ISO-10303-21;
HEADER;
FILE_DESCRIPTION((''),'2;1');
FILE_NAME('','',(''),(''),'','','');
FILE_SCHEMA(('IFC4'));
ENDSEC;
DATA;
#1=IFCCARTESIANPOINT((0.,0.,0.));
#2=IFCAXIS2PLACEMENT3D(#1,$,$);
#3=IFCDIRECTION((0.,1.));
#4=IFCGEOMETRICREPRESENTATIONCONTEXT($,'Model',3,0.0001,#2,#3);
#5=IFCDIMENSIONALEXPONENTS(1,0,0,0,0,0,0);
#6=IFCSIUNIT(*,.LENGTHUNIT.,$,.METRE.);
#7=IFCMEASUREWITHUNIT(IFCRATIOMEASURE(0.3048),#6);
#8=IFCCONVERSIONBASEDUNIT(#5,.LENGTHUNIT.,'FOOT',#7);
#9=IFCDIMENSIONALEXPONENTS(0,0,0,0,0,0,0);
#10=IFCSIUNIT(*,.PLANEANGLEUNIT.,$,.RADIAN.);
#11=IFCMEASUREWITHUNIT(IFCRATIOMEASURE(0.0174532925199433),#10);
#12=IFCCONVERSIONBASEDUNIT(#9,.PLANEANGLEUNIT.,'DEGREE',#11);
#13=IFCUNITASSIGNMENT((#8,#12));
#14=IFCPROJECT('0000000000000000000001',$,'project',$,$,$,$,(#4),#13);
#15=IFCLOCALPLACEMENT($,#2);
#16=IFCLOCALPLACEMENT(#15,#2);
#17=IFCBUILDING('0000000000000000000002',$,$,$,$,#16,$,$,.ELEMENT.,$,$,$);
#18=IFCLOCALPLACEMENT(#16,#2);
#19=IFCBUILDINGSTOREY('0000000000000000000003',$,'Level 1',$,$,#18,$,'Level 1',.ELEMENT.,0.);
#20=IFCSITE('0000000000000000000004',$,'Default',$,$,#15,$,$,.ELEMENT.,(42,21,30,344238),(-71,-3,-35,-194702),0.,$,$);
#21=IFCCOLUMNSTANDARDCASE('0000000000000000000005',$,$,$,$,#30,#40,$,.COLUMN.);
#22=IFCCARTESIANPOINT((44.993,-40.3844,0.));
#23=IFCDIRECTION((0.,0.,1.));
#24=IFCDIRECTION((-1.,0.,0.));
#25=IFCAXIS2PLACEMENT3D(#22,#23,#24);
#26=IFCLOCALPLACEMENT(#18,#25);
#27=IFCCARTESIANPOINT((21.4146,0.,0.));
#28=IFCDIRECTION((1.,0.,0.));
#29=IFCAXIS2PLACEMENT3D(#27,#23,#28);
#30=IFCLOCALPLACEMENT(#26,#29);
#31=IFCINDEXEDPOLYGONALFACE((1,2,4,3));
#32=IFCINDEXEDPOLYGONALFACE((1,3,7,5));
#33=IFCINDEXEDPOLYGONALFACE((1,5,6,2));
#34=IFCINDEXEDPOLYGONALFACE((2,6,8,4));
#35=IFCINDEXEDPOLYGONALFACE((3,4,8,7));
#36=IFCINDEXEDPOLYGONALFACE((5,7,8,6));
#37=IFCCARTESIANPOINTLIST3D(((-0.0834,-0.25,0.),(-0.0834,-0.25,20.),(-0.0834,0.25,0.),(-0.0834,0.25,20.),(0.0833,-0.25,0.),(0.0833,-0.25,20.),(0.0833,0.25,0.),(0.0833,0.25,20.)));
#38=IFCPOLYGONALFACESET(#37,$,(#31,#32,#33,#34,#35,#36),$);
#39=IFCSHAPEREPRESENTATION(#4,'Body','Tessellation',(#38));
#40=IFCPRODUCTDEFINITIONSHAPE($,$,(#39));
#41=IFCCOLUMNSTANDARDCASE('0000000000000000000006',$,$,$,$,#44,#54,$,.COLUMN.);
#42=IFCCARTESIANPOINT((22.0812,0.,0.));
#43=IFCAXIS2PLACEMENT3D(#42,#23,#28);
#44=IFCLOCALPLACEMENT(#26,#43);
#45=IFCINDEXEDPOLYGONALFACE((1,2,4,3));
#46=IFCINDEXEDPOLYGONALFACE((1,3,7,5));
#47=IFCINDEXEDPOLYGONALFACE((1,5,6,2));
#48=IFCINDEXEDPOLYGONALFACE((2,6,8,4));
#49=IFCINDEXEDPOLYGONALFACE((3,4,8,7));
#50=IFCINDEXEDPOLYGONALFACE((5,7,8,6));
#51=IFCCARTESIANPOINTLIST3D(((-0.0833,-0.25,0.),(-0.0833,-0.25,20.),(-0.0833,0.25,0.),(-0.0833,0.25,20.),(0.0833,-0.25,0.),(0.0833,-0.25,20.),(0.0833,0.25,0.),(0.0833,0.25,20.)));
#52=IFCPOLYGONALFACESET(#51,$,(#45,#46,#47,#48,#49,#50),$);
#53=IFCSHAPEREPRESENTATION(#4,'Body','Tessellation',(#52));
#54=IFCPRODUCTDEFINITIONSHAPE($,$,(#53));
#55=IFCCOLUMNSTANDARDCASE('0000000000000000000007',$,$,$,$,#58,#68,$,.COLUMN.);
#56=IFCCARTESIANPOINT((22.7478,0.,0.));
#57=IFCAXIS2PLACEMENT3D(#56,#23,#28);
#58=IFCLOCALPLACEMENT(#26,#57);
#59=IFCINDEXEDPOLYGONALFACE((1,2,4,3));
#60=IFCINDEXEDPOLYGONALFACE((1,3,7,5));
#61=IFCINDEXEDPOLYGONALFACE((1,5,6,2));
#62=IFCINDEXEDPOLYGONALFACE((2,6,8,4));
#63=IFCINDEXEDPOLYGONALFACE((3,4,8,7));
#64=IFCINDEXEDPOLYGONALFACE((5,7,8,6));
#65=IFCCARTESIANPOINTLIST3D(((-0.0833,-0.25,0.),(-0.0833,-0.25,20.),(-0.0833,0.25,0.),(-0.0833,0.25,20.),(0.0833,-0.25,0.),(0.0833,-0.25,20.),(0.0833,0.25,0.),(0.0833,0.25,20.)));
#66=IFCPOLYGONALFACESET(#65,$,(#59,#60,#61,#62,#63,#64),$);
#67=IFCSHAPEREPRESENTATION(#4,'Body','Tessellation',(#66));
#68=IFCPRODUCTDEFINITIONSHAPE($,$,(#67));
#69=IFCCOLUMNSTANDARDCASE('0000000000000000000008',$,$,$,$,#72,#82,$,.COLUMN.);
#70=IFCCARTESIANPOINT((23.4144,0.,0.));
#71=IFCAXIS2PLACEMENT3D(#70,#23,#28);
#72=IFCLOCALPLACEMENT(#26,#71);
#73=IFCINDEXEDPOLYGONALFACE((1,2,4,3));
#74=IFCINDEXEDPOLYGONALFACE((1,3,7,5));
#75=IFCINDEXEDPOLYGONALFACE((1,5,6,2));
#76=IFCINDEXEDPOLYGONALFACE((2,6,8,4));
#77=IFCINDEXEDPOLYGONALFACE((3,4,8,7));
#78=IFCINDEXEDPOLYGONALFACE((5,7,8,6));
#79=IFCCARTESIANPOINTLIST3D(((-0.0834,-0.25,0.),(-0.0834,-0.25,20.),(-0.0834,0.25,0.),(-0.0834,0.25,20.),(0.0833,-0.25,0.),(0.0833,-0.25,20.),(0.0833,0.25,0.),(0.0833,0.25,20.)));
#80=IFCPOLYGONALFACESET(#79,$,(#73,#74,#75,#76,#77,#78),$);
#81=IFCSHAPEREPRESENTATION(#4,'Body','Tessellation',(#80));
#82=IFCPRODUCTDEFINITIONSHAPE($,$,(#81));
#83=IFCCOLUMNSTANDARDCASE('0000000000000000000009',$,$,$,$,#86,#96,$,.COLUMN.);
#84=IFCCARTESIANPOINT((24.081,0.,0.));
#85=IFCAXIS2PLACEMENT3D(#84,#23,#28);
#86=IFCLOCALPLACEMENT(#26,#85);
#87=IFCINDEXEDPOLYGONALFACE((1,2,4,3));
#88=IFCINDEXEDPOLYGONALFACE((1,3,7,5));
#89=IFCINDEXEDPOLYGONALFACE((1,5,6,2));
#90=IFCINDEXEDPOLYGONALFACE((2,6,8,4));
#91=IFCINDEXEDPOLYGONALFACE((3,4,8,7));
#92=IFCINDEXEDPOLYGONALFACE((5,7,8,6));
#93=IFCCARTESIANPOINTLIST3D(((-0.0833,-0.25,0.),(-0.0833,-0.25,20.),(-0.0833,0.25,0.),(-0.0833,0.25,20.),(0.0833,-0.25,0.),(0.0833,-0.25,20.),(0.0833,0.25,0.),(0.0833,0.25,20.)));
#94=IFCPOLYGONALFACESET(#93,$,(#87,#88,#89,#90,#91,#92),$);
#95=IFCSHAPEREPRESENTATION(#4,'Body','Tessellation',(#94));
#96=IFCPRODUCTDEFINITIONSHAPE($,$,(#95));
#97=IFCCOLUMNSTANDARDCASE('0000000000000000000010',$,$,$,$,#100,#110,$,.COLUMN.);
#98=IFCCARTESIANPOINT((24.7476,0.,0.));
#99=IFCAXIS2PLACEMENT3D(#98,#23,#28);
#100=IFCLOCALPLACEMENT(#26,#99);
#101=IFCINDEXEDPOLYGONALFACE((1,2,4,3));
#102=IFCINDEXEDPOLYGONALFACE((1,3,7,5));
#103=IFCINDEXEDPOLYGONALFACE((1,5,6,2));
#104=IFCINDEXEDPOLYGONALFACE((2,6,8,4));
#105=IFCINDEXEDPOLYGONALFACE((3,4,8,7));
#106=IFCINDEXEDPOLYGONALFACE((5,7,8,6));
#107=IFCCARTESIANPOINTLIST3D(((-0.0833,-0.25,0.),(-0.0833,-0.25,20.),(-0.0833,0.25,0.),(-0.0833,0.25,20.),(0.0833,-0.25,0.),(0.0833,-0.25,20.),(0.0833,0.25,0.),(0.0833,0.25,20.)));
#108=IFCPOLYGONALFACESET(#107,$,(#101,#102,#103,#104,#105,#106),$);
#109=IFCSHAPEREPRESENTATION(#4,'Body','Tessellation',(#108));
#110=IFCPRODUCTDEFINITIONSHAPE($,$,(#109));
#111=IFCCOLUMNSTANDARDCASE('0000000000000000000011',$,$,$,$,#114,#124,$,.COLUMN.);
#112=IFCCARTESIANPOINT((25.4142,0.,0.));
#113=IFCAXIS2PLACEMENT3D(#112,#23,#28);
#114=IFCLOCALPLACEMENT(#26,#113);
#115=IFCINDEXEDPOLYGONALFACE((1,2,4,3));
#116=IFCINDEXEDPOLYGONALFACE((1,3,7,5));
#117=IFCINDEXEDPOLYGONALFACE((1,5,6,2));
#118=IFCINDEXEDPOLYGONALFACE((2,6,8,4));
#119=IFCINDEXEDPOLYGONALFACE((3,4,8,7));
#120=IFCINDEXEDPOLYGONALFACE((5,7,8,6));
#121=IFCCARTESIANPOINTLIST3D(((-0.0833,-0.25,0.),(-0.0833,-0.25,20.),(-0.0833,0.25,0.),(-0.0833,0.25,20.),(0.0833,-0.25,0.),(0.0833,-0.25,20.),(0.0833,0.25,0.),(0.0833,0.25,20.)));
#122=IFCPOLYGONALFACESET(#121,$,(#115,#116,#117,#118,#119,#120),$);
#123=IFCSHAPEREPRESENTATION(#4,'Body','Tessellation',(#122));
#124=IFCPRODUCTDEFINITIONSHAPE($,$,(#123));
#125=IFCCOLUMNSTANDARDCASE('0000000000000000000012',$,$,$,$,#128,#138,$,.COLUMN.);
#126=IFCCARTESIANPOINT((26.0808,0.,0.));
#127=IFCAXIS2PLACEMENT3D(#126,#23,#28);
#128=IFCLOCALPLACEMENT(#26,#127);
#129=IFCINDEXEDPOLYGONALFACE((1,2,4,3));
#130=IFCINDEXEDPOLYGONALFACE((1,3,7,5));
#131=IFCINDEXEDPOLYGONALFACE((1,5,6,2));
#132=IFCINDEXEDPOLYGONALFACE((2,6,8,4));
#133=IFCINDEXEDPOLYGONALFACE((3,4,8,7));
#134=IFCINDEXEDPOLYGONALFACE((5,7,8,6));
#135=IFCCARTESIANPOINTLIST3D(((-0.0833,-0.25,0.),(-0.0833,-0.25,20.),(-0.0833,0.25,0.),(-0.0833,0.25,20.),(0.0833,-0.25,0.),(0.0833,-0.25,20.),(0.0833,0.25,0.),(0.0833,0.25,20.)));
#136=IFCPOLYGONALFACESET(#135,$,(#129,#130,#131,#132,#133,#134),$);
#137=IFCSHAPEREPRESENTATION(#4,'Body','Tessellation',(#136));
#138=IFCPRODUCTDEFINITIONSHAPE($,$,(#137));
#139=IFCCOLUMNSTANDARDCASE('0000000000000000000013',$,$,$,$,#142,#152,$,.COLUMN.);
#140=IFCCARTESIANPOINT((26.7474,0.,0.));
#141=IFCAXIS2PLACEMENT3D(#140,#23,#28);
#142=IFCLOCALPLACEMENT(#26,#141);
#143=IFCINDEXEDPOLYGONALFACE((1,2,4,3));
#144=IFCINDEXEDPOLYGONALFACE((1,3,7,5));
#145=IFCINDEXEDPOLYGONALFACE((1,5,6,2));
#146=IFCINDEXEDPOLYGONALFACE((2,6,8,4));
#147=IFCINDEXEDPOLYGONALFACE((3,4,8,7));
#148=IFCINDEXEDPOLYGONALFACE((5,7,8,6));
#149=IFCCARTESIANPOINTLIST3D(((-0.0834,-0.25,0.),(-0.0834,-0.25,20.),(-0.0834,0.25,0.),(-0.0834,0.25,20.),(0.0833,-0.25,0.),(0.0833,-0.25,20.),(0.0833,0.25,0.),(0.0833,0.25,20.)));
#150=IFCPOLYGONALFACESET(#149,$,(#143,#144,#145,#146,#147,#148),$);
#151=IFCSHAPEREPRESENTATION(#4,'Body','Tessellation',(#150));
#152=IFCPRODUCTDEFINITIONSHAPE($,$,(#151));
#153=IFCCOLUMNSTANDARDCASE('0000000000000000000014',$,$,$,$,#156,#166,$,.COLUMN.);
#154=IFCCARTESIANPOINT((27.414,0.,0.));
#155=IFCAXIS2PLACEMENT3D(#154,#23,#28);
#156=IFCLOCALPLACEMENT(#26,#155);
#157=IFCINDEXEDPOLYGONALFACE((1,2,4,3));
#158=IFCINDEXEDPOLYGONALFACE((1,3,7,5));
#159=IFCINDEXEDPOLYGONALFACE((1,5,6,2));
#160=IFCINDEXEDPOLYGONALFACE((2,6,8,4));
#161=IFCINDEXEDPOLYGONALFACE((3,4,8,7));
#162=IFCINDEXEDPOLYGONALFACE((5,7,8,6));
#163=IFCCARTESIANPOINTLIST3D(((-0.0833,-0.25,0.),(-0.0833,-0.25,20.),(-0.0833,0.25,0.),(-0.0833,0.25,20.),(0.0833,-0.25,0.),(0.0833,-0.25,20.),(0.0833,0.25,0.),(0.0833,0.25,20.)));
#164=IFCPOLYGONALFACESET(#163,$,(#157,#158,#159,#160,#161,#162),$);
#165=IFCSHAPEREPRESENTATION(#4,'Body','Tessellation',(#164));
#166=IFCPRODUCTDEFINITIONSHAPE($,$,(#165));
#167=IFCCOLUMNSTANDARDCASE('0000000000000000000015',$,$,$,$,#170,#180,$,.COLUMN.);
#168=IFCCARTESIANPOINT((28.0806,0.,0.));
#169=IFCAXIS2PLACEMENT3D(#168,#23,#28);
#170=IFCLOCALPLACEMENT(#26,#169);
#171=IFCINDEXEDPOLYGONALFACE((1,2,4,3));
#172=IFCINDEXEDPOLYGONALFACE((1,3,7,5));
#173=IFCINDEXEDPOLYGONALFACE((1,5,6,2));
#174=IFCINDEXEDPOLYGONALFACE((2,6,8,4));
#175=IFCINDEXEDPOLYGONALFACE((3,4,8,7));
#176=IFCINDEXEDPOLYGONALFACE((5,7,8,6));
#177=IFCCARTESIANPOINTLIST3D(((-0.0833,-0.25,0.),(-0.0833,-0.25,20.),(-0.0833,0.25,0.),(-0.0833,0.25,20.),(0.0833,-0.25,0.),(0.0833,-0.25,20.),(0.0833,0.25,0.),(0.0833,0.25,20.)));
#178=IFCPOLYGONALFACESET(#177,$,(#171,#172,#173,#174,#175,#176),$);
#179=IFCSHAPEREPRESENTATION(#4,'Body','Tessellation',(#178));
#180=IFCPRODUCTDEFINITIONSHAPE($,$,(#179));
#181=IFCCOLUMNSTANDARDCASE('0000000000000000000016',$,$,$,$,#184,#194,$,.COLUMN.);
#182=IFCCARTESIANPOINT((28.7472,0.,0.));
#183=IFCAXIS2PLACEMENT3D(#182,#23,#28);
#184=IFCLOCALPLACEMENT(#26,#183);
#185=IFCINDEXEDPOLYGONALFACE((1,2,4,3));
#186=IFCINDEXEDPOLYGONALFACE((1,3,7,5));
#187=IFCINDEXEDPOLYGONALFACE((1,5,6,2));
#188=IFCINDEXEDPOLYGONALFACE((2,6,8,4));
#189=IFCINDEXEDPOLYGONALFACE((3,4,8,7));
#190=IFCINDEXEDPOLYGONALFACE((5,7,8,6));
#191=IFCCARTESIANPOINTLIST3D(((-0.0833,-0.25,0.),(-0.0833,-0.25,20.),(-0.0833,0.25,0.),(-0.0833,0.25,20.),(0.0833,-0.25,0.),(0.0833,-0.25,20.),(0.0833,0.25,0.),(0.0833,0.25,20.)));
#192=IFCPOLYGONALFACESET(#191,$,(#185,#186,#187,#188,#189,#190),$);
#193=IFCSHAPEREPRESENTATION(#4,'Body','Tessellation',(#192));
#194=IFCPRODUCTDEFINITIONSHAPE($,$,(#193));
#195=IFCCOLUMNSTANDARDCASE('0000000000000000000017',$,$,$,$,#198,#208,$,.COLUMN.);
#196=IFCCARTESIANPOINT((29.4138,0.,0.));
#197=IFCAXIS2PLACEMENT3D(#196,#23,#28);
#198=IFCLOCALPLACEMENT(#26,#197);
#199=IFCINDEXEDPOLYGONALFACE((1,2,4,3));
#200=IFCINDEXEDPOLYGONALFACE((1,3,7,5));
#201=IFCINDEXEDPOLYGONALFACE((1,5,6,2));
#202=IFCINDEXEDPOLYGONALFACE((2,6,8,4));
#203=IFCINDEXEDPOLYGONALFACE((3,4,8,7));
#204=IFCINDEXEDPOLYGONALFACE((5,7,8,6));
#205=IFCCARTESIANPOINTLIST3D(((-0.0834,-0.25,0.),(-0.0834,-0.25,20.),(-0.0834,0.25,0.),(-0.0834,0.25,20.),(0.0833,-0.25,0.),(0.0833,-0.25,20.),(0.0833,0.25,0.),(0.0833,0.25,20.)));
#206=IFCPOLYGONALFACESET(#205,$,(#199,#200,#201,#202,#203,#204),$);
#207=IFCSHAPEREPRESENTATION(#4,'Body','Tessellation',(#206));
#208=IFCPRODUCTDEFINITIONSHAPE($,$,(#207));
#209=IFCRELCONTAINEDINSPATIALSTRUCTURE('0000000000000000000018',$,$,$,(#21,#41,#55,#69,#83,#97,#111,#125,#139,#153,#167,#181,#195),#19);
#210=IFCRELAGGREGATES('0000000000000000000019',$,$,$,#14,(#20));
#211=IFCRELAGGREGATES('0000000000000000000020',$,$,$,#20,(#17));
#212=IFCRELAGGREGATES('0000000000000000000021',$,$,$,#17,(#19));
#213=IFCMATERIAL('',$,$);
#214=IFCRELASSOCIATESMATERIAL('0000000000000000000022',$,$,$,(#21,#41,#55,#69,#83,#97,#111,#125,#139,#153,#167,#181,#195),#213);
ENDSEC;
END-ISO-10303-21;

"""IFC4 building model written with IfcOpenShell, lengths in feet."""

from ifc_helpers import new_model, entity, si_unit, converted_unit, direction, frame, origin, place, context, project, spatial, rectangle, extrude, material, element, save


model = new_model("IFC4")

# Units and contexts
model_context = context("Model", 3, precision=0.0001, world=origin(), true_north=direction((0.0, 1.0)))
ifc_project = project(units=[converted_unit("LENGTHUNIT", "FOOT", entity("IfcRatioMeasure", 0.3048), si_unit("LENGTHUNIT", "METRE"), dimensions=[1, 0, 0, 0, 0, 0, 0]), converted_unit("PLANEANGLEUNIT", "DEGREE", entity("IfcRatioMeasure", 0.0174532925199433), si_unit("PLANEANGLEUNIT", "RADIAN"), dimensions=[0, 0, 0, 0, 0, 0, 0])], contexts=[model_context])

# Site, building, storey
site_placement = place(None, origin())
site = spatial("IfcSite", under=ifc_project, at=site_placement, Name="Default", CompositionType="ELEMENT", RefLatitude=(42, 21, 30, 344238), RefLongitude=(-71, -3, -35, -194702), RefElevation=0.0)
building_placement = place(site_placement, origin())
building = spatial("IfcBuilding", under=site, at=building_placement, CompositionType="ELEMENT")
storey_placement = place(building_placement, origin())
storey = spatial("IfcBuildingStorey", under=building, at=storey_placement, Name="Level 1", LongName="Level 1", CompositionType="ELEMENT", Elevation=0.0)

# Columns
ifc_material = material(Name="")
placement = place(storey_placement, frame((44.993, -40.3844, 0.0), z_axis=(0.0, 0.0, 1.0), x_axis=(-1.0, 0.0, 0.0)))
for number, where, z_axis, x_axis in (
    (1, (21.4146, 0.0, 0.0), (0.0, 0.0, 1.0), (1.0, 0.0, 0.0)),
    (2, (22.0812, 0.0, 0.0), (0.0, 0.0, 1.0), (1.0, 0.0, 0.0)),
    (3, (22.7478, 0.0, 0.0), (0.0, 0.0, 1.0), (1.0, 0.0, 0.0)),
    (4, (23.4144, 0.0, 0.0), (0.0, 0.0, 1.0), (1.0, 0.0, 0.0)),
    (5, (24.081, 0.0, 0.0), (0.0, 0.0, 1.0), (1.0, 0.0, 0.0)),
    (6, (24.7476, 0.0, 0.0), (0.0, 0.0, 1.0), (1.0, 0.0, 0.0)),
    (7, (25.4142, 0.0, 0.0), (0.0, 0.0, 1.0), (1.0, 0.0, 0.0)),
    (8, (26.0808, 0.0, 0.0), (0.0, 0.0, 1.0), (1.0, 0.0, 0.0)),
    (9, (26.7474, 0.0, 0.0), (0.0, 0.0, 1.0), (1.0, 0.0, 0.0)),
    (10, (27.414, 0.0, 0.0), (0.0, 0.0, 1.0), (1.0, 0.0, 0.0)),
    (11, (28.0806, 0.0, 0.0), (0.0, 0.0, 1.0), (1.0, 0.0, 0.0)),
    (12, (28.7472, 0.0, 0.0), (0.0, 0.0, 1.0), (1.0, 0.0, 0.0)),
    (13, (29.4138, 0.0, 0.0), (0.0, 0.0, 1.0), (1.0, 0.0, 0.0)),
):
    element("IfcColumnStandardCase", number, at=place(placement, frame(where, z_axis=z_axis, x_axis=x_axis)), inside=storey, material=ifc_material, PredefinedType="COLUMN", context=model_context, shape_type="SweptSolid", body=[
        extrude(rectangle(XDim=0.1667, YDim=0.5), origin(), (0.0, 0.0, 1.0), 20.0),
    ])

save(model, "model.ifc")
